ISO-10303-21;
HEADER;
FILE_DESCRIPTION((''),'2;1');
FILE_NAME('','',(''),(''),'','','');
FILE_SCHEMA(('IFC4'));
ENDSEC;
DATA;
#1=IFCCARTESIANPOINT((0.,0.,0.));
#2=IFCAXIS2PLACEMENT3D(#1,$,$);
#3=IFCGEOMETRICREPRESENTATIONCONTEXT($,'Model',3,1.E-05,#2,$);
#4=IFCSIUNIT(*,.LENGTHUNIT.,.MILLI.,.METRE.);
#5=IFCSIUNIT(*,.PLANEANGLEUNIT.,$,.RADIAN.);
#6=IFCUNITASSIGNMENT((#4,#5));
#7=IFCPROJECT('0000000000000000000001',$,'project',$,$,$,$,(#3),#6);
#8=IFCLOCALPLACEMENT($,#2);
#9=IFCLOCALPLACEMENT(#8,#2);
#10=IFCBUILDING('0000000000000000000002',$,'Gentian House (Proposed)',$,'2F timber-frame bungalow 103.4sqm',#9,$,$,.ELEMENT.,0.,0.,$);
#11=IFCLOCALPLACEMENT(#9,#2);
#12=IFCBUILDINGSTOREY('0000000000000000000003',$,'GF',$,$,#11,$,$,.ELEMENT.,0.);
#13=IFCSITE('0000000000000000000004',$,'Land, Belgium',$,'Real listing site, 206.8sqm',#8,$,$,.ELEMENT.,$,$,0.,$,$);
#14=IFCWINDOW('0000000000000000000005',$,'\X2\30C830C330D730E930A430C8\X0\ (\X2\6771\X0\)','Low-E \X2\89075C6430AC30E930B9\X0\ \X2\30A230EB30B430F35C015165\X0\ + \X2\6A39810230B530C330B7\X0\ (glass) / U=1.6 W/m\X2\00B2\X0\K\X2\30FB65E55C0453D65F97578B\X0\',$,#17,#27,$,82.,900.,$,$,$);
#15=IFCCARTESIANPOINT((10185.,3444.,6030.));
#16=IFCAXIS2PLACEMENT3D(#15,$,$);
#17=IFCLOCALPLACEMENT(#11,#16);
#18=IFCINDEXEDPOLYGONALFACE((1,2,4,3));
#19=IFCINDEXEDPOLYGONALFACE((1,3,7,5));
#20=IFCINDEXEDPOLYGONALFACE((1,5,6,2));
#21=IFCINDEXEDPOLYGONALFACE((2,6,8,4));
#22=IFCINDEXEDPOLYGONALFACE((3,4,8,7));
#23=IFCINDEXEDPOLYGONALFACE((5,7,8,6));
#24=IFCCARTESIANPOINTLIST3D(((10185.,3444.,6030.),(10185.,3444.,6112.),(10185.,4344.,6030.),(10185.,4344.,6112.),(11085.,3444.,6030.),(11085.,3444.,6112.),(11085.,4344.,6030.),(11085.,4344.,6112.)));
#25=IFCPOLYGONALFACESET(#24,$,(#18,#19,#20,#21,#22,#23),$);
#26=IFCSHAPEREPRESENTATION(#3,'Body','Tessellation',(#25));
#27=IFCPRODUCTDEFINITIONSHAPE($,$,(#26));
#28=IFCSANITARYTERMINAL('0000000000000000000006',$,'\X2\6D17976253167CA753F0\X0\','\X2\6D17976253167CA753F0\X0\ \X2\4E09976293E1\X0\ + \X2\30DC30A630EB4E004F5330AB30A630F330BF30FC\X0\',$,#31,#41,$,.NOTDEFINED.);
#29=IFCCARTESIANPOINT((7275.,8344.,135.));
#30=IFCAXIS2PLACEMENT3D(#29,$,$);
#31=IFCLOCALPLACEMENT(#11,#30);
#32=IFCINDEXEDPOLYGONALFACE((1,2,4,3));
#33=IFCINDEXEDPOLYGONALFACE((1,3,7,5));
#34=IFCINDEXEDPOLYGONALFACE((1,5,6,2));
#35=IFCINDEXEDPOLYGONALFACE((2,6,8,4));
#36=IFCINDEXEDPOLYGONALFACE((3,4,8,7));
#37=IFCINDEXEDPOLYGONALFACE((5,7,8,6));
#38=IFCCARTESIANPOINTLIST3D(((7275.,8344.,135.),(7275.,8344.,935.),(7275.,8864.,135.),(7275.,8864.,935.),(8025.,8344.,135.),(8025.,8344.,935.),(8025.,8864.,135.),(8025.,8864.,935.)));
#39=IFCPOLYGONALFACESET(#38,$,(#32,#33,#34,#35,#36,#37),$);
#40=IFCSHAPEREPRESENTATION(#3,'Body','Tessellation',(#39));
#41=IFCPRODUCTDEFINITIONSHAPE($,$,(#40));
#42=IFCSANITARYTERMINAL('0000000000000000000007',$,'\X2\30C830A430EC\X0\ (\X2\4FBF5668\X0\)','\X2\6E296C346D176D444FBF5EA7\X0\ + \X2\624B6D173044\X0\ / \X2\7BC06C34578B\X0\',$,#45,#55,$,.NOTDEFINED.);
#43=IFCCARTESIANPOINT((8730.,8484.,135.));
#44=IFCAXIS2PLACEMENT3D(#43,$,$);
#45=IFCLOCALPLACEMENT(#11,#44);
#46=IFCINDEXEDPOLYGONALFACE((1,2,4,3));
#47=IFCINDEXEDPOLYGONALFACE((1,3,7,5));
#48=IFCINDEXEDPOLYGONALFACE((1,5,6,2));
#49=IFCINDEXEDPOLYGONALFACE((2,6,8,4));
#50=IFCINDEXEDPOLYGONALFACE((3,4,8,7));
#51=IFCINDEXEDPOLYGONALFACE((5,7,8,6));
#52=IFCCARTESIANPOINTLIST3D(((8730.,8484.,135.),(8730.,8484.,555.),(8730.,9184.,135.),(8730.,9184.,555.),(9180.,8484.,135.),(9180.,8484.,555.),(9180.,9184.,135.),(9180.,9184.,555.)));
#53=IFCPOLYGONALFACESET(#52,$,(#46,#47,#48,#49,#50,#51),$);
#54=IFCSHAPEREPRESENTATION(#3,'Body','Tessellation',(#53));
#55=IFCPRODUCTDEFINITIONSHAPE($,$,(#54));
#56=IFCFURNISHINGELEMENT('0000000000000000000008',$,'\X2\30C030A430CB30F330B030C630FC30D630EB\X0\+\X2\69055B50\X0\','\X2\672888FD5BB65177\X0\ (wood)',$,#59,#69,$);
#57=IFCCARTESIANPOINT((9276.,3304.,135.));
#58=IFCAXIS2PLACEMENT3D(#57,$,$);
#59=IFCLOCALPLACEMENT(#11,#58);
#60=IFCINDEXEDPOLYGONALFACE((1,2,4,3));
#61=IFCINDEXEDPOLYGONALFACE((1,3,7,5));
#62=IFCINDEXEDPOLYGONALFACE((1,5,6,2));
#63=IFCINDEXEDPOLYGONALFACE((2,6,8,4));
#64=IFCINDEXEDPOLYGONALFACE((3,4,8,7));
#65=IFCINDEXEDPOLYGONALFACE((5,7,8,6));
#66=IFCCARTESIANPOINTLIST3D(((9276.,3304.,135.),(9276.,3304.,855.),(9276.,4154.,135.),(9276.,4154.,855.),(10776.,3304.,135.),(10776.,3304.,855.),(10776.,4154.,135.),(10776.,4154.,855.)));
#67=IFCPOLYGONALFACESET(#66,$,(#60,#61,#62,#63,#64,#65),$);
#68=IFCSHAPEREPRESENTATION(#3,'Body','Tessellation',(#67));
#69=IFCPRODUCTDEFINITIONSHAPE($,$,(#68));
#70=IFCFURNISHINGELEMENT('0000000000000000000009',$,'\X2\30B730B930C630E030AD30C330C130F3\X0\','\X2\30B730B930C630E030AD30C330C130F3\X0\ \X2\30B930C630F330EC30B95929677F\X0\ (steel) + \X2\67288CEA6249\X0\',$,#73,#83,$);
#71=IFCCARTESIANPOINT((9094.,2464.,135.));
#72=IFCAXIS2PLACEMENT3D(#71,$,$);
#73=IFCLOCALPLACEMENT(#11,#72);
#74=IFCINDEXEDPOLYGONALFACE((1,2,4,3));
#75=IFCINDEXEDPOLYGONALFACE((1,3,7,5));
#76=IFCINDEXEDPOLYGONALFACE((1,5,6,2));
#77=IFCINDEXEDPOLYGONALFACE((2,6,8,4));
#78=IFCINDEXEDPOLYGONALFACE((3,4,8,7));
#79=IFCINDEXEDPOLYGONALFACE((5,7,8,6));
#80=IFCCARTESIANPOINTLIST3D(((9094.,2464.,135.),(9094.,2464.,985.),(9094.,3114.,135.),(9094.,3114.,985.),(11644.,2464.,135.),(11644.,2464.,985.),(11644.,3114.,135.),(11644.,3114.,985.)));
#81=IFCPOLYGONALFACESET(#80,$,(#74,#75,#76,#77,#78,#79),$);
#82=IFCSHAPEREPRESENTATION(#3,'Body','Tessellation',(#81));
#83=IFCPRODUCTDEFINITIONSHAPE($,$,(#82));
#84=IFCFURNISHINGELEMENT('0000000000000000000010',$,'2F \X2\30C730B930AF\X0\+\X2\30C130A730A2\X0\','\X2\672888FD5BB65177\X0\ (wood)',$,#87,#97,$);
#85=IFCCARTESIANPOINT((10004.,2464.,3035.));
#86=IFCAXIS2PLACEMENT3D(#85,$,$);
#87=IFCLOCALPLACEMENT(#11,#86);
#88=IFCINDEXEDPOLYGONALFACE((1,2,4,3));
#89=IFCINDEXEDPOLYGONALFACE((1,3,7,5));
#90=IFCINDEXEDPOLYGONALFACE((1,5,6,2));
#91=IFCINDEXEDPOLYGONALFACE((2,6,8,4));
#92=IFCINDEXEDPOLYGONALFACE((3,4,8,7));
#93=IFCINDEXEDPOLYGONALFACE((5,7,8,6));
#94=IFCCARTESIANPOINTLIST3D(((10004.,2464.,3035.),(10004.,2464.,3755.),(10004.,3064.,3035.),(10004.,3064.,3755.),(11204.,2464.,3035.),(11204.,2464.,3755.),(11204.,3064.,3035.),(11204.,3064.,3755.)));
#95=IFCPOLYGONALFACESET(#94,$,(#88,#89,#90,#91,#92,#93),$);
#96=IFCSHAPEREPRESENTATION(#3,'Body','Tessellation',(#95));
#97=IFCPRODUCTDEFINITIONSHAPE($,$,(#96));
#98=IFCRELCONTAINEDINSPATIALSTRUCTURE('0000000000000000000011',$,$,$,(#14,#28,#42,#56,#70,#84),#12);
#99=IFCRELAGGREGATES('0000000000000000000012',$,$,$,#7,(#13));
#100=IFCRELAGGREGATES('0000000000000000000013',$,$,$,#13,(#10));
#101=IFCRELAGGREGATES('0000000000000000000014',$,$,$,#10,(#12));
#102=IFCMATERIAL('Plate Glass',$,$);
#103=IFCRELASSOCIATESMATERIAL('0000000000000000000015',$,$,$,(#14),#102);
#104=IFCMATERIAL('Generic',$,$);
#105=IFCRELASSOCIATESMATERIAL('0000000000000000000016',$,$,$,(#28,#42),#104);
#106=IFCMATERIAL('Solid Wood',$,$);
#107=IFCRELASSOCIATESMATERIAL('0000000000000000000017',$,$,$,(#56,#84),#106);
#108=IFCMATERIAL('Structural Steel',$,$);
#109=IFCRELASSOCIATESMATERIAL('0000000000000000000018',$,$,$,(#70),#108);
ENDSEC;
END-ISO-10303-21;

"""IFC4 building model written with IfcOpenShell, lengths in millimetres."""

from ifc_helpers import new_model, si_unit, frame, frame_2d, origin, place, context, project, spatial, rectangle, extrude, material, element, save


model = new_model("IFC4")

# Units and contexts
model_context = context("Model", 3, precision=1e-05, world=origin())
ifc_project = project(units=[si_unit("LENGTHUNIT", "METRE", prefix="MILLI"), si_unit("PLANEANGLEUNIT", "RADIAN")], contexts=[model_context])

# Site, building, storey
site_placement = place(None, origin())
site = spatial("IfcSite", under=ifc_project, at=site_placement, Name="Land, Belgium", ObjectType="Real listing site, 206.8sqm", CompositionType="ELEMENT", RefElevation=0.0)
building_placement = place(site_placement, origin())
building = spatial("IfcBuilding", under=site, at=building_placement, Name="Gentian House (Proposed)", ObjectType="2F timber-frame bungalow 103.4sqm", CompositionType="ELEMENT", ElevationOfRefHeight=0.0, ElevationOfTerrain=0.0)
storey_placement = place(building_placement, origin())
storey = spatial("IfcBuildingStorey", under=building, at=storey_placement, Name="GF", CompositionType="ELEMENT", Elevation=0.0)

# Shared definitions
ifc_material_1 = material(Name="Solid Wood")

# Shared definitions
ifc_material_2 = material(Name="Plate Glass")

# Window
window_1_placement = place(storey_placement, frame((10185.0, 3444.0, 6030.0)))
element("IfcWindow", 1, at=window_1_placement, inside=storey, material=ifc_material_2, Name="トップライト (東)", Description="Low-E 複層ガラス アルゴン封入 + 樹脂サッシ (glass) / U=1.6 W/m²K・日射取得型", OverallHeight=82.0, OverallWidth=900.0, context=model_context, shape_type="SweptSolid", body=[
    extrude(rectangle(XDim=900.0, YDim=900.0, at=frame_2d((450.0, 450.0))), frame((10185.0, 3444.0, 6030.0)), (0.0, 0.0, 1.0), 82.0),
])

# Sanitary terminals
ifc_material_3 = material(Name="Generic")
sanitary_terminal_1_placement = place(storey_placement, frame((7275.0, 8344.0, 135.0)))
element("IfcSanitaryTerminal", 2, at=sanitary_terminal_1_placement, inside=storey, material=ifc_material_3, Name="洗面化粧台", Description="洗面化粧台 三面鏡 + ボウル一体カウンター", PredefinedType="NOTDEFINED", context=model_context, shape_type="SweptSolid", body=[
    extrude(rectangle(XDim=750.0, YDim=520.0, at=frame_2d((375.0, 260.0))), frame((7275.0, 8344.0, 135.0)), (0.0, 0.0, 1.0), 800.0),
])
sanitary_terminal_2_placement = place(storey_placement, frame((8730.0, 8484.0, 135.0)))
element("IfcSanitaryTerminal", 3, at=sanitary_terminal_2_placement, inside=storey, material=ifc_material_3, Name="トイレ (便器)", Description="温水洗浄便座 + 手洗い / 節水型", PredefinedType="NOTDEFINED", context=model_context, shape_type="SweptSolid", body=[
    extrude(rectangle(XDim=450.0, YDim=700.0, at=frame_2d((225.0, 350.0))), frame((8730.0, 8484.0, 135.0)), (0.0, 0.0, 1.0), 420.0),
])

# Furnishing elements
furnishing_1_placement = place(storey_placement, frame((9276.0, 3304.0, 135.0)))
element("IfcFurnishingElement", 4, at=furnishing_1_placement, inside=storey, material=ifc_material_1, Name="ダイニングテーブル+椅子", Description="木製家具 (wood)", context=model_context, shape_type="SweptSolid", body=[
    extrude(rectangle(XDim=1500.0, YDim=850.0, at=frame_2d((750.0, 425.0))), frame((9276.0, 3304.0, 135.0)), (0.0, 0.0, 1.0), 720.0),
])
ifc_material_4 = material(Name="Structural Steel")
furnishing_2_placement = place(storey_placement, frame((9094.0, 2464.0, 135.0)))
element("IfcFurnishingElement", 5, at=furnishing_2_placement, inside=storey, material=ifc_material_4, Name="システムキッチン", Description="システムキッチン ステンレス天板 (steel) + 木質扉", context=model_context, shape_type="SweptSolid", body=[
    extrude(rectangle(XDim=2550.0, YDim=650.0, at=frame_2d((1275.0, 325.0))), frame((9094.0, 2464.0, 135.0)), (0.0, 0.0, 1.0), 850.0),
])
furnishing_3_placement = place(storey_placement, frame((10004.0, 2464.0, 3035.0)))
element("IfcFurnishingElement", 6, at=furnishing_3_placement, inside=storey, material=ifc_material_1, Name="2F デスク+チェア", Description="木製家具 (wood)", context=model_context, shape_type="SweptSolid", body=[
    extrude(rectangle(XDim=1200.0, YDim=600.0, at=frame_2d((600.0, 300.0))), frame((10004.0, 2464.0, 3035.0)), (0.0, 0.0, 1.0), 720.0),
])

save(model, "model.ifc")
